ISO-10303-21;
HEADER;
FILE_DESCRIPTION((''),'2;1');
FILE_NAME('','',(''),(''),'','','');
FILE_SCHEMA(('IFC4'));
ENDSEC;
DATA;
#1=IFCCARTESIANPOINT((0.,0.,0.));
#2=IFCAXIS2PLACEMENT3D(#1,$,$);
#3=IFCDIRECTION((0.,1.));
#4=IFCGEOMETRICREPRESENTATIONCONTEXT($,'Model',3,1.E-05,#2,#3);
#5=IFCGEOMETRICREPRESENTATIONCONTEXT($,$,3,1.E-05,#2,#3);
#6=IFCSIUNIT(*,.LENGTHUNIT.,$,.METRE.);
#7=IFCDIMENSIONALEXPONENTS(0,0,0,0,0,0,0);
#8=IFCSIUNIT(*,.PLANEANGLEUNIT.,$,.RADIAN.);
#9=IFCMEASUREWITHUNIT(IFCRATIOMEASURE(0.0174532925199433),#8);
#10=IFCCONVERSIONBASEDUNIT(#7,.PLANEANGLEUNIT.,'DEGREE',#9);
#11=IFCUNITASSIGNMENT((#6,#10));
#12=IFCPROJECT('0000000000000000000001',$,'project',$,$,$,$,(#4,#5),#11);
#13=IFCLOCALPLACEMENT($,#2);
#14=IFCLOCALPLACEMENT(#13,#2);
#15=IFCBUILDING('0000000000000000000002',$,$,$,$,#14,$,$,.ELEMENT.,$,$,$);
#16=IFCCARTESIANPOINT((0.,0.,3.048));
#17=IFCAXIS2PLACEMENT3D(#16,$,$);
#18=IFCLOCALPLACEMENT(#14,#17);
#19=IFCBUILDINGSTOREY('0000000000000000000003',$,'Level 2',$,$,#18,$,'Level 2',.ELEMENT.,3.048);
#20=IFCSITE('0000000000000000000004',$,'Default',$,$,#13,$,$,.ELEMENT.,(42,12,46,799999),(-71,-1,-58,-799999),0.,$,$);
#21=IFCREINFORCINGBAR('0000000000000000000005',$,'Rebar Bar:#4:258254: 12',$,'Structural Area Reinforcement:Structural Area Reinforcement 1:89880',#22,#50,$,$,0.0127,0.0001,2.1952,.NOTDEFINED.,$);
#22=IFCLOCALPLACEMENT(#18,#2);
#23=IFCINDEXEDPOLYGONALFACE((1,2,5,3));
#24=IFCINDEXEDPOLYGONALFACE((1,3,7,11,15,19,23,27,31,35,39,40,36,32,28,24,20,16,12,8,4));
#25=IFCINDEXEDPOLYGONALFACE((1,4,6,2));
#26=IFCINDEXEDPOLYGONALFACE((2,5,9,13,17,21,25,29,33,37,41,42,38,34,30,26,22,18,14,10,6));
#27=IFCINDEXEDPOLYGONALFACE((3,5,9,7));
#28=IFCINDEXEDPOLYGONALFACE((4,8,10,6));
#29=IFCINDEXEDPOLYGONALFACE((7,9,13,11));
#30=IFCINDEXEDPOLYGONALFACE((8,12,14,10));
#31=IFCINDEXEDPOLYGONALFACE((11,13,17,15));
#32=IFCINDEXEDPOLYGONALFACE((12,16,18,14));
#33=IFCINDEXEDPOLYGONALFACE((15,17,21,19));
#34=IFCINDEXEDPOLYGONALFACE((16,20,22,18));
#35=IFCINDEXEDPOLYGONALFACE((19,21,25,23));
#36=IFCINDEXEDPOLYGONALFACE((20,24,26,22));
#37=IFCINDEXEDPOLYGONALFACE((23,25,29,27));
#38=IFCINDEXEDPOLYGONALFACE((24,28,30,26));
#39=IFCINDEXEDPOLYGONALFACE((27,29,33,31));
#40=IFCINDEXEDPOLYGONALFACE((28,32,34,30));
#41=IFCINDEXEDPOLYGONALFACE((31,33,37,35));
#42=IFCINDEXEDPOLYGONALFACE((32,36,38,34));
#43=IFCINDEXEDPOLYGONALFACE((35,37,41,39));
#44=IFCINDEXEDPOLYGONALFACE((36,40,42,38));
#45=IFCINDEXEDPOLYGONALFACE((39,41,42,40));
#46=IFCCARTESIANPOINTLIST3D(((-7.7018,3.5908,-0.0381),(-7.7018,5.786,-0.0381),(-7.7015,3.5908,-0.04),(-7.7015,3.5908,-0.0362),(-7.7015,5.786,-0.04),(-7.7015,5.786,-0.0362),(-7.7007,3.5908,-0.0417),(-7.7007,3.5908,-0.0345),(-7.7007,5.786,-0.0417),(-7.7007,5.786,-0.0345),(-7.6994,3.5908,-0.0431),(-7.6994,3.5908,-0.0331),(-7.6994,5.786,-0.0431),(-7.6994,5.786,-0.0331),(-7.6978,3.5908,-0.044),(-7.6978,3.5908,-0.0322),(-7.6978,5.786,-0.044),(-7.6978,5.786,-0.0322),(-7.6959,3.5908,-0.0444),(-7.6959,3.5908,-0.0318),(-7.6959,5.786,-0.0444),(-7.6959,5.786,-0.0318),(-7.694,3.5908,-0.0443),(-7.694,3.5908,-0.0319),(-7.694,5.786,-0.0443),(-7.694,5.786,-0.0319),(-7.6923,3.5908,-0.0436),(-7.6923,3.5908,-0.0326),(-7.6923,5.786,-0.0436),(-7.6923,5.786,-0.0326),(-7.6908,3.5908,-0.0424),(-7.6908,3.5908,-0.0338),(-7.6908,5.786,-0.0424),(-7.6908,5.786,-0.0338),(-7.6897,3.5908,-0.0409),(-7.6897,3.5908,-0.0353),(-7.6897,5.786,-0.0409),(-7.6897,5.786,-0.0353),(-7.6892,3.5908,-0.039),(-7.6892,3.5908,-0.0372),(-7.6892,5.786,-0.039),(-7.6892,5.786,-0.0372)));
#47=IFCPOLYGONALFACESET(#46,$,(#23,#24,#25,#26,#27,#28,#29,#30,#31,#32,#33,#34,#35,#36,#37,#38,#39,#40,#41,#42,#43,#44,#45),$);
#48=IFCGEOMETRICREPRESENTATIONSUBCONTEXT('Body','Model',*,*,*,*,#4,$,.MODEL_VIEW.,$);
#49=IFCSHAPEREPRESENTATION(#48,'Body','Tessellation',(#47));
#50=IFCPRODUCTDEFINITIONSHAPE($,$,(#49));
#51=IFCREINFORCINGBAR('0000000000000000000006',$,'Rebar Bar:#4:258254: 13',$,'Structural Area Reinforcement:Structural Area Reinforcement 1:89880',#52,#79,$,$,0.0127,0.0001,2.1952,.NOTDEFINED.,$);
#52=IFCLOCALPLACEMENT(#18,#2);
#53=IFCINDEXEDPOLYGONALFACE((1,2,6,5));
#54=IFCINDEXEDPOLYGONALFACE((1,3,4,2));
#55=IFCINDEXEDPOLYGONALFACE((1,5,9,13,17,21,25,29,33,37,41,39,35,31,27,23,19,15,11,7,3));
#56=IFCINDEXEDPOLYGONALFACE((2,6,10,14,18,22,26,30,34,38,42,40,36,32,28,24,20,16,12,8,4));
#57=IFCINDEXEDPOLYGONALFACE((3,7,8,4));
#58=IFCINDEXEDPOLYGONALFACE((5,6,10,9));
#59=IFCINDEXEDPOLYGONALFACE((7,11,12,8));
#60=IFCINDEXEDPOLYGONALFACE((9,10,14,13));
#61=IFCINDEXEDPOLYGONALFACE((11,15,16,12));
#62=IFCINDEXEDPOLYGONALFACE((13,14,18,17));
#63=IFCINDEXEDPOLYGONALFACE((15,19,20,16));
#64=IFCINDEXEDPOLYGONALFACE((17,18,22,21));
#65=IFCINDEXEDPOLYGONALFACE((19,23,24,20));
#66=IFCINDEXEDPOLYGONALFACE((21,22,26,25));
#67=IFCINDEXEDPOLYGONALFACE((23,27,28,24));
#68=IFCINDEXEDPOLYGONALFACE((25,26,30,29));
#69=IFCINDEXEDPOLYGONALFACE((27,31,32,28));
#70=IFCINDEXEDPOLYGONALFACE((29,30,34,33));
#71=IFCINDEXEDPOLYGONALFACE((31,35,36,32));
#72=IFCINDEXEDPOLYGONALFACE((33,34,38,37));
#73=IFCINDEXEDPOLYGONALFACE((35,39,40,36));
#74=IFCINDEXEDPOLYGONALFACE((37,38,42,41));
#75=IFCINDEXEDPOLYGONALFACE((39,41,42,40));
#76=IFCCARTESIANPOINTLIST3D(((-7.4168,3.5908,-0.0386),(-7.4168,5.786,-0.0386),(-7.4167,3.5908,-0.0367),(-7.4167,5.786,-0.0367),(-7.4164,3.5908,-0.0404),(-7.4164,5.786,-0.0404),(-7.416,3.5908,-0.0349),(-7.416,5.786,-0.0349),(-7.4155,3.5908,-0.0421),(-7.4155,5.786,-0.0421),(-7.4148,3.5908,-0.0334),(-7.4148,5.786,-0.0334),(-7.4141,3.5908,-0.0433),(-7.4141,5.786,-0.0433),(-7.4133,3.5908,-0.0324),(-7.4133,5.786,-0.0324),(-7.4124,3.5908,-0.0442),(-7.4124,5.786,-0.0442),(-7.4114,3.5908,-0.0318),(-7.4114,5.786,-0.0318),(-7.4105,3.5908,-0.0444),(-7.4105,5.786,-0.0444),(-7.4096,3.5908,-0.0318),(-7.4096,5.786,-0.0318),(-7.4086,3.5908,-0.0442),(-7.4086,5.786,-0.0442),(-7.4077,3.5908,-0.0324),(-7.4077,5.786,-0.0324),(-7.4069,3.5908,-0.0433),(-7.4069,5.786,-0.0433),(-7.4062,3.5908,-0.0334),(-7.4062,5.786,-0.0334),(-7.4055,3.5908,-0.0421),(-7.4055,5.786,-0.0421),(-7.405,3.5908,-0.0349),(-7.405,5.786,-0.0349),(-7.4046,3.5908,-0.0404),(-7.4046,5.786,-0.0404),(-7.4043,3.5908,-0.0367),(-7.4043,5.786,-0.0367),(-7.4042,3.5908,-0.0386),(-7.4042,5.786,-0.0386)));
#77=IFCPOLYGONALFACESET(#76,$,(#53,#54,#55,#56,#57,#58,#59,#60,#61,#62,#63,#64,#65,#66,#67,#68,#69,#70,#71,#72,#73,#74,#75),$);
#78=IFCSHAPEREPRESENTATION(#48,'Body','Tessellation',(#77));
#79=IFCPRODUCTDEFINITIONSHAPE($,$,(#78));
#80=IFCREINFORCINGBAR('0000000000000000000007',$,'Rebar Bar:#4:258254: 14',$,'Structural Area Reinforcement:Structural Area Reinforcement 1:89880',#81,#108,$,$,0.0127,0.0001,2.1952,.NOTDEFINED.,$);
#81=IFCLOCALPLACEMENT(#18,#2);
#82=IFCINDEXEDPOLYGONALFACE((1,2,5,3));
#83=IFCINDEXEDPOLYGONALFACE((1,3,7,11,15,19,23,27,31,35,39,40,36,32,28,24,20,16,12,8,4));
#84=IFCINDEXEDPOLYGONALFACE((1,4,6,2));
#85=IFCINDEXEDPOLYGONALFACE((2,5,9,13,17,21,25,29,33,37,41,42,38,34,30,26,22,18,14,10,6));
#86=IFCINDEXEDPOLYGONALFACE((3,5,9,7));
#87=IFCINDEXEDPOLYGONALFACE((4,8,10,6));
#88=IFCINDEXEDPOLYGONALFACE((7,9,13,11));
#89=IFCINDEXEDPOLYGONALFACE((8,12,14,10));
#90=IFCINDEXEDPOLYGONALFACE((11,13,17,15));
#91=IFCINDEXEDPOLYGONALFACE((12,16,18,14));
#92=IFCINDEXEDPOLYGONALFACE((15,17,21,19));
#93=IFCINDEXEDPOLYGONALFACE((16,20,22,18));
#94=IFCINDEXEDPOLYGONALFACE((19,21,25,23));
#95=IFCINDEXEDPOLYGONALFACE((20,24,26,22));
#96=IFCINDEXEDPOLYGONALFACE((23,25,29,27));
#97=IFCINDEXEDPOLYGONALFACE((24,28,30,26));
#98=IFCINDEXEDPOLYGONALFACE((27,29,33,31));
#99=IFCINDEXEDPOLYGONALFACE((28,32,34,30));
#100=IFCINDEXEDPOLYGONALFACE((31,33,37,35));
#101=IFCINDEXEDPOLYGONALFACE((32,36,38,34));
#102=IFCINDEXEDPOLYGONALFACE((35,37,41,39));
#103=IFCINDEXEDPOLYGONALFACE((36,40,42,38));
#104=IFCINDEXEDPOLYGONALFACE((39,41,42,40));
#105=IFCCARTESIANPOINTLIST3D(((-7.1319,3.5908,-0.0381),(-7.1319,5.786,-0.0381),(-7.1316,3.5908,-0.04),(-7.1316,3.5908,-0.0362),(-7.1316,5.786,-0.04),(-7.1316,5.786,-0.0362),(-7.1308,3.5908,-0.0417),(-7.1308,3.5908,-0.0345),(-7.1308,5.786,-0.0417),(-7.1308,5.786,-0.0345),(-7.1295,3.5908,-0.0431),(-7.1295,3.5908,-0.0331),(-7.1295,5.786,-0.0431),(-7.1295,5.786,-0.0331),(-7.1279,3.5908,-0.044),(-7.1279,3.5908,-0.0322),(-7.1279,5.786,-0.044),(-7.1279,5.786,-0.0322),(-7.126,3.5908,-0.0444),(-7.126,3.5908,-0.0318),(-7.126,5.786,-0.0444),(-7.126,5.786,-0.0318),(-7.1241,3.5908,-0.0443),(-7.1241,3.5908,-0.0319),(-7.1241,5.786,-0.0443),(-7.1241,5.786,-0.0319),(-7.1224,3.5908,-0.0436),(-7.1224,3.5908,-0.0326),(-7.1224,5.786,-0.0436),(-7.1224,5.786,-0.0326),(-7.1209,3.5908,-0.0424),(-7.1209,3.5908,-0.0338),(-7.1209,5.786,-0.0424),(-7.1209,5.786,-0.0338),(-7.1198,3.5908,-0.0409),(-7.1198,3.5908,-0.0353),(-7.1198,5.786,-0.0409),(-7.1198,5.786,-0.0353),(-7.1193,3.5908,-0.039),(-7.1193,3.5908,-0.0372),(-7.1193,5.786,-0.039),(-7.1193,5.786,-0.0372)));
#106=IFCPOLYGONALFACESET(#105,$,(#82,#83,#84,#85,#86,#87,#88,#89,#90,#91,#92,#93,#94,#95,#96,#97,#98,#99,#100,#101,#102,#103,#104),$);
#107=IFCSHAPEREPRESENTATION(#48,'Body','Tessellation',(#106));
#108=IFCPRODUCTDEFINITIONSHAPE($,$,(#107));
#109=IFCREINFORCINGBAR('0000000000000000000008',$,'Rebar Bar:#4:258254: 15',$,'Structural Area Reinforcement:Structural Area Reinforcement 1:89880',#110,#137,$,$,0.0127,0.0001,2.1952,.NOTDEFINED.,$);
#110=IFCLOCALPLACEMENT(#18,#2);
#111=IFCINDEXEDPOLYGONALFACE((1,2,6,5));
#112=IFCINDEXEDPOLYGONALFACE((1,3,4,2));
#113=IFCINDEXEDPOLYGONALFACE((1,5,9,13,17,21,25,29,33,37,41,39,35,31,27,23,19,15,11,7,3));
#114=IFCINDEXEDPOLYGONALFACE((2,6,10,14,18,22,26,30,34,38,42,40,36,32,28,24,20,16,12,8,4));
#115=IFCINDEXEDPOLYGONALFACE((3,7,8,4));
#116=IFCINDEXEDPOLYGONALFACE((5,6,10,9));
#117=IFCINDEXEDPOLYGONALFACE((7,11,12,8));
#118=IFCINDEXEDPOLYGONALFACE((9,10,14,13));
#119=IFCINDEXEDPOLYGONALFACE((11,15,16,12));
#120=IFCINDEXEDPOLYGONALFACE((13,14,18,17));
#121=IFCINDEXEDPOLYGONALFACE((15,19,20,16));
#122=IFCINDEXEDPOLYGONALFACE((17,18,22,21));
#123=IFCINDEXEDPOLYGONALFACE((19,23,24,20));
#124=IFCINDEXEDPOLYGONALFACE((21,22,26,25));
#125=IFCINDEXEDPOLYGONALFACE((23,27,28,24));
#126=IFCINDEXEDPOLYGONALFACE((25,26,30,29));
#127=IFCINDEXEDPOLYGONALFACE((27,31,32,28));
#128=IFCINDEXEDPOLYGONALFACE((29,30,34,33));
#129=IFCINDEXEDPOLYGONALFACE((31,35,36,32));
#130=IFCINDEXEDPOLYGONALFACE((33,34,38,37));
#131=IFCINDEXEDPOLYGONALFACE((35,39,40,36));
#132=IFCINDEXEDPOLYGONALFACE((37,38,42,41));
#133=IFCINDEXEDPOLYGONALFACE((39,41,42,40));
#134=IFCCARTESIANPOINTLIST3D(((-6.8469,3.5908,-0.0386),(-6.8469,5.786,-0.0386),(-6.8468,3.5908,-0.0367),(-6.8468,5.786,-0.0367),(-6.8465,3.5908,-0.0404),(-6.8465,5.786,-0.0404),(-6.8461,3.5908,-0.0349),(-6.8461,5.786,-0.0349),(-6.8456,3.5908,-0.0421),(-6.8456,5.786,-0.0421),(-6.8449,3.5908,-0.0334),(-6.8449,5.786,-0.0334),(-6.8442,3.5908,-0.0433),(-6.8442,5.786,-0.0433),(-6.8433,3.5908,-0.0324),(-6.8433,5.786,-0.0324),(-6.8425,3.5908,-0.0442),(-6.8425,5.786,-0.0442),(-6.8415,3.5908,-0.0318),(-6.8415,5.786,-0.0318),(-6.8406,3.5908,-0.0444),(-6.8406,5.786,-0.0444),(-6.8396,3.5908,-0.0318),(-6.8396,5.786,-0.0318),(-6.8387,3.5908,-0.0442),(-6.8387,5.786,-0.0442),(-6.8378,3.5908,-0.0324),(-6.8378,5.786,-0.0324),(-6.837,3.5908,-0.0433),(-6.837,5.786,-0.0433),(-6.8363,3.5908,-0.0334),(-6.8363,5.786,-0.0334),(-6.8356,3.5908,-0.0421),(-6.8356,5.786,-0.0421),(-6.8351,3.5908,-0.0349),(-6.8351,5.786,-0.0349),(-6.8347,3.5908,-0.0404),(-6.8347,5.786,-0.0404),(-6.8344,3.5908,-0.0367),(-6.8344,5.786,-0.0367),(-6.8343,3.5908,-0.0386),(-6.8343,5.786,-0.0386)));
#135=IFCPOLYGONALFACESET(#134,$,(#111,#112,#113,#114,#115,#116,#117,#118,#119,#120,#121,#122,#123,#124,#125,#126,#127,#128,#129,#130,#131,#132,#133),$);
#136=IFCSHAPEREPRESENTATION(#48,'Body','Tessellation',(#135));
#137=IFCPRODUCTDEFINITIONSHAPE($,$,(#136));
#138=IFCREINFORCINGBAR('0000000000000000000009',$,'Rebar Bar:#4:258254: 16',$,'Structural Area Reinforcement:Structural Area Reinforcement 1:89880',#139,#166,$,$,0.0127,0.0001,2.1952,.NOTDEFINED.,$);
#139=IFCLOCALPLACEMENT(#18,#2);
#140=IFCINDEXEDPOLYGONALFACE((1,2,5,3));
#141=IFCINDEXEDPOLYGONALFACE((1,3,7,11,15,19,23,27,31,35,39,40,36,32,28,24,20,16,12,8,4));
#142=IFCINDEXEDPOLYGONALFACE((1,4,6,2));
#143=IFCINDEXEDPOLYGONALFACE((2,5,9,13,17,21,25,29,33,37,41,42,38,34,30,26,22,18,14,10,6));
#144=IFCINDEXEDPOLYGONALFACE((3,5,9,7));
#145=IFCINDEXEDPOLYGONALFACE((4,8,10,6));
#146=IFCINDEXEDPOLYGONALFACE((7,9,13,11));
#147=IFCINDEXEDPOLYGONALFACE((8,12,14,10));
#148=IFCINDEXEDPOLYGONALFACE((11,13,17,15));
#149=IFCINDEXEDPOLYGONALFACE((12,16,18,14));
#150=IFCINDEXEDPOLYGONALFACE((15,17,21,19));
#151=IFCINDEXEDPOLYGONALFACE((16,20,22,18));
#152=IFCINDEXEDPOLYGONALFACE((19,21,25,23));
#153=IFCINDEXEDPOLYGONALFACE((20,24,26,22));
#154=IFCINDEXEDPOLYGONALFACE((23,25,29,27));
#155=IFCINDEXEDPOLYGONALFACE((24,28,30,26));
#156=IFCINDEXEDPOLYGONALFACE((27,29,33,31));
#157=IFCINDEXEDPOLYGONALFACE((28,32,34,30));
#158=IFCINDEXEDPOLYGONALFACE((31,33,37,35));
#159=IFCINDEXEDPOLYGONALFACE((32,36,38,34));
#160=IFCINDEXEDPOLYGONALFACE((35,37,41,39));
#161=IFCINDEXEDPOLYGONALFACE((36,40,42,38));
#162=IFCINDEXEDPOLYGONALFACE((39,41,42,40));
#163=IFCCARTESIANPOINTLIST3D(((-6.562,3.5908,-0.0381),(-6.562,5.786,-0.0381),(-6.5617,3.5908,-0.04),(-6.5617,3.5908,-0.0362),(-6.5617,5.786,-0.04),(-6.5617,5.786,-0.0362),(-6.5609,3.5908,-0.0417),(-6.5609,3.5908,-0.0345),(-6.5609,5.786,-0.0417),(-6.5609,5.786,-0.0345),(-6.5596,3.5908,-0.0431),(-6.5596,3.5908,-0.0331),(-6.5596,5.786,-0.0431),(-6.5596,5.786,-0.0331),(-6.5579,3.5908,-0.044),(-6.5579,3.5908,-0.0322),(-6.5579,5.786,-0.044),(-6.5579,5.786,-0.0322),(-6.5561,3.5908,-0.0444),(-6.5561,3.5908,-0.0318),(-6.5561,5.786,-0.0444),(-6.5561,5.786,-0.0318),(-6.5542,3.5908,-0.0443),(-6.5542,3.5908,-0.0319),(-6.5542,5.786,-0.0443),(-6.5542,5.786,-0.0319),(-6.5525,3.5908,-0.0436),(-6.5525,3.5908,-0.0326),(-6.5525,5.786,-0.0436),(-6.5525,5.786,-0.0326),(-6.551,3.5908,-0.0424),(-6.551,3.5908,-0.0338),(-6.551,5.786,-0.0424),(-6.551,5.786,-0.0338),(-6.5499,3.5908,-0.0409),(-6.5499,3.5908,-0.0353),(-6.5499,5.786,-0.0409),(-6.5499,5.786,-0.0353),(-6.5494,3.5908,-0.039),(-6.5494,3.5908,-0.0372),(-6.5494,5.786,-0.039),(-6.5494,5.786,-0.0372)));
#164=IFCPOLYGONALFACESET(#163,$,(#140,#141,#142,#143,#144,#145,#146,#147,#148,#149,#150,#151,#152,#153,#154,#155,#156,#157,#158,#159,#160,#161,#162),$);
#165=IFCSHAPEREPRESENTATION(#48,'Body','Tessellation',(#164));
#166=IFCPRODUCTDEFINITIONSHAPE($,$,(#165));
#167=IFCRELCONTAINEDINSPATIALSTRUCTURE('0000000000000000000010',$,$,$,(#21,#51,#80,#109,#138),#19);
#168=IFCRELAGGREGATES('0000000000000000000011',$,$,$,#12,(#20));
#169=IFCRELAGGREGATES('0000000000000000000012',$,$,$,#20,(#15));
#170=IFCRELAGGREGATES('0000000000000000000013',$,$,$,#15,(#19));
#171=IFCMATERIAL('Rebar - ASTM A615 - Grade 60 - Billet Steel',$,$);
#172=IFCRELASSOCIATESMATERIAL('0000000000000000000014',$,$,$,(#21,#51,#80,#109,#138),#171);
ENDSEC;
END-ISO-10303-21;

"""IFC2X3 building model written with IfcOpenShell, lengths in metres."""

from ifc_helpers import new_model, entity, si_unit, converted_unit, direction, frame, origin, place, context, subcontext, project, spatial, material, element, save


model = new_model("IFC2X3")

# Units and contexts
model_context = context("Model", 3, precision=1e-05, world=origin(), true_north=direction((0.0, 1.0)))
context_of_model = context(None, 3, precision=1e-05, world=origin(), true_north=direction((0.0, 1.0)))
body_context = subcontext(model_context, "Body", "Model", "MODEL_VIEW")
ifc_project = project(units=[si_unit("LENGTHUNIT", "METRE"), converted_unit("PLANEANGLEUNIT", "DEGREE", entity("IfcRatioMeasure", 0.0174532925199433), si_unit("PLANEANGLEUNIT", "RADIAN"), dimensions=[0, 0, 0, 0, 0, 0, 0])], contexts=[model_context, context_of_model])

# Site, building, storey
site_placement = place(None, origin())
site = spatial("IfcSite", under=ifc_project, at=site_placement, Name="Default", CompositionType="ELEMENT", RefLatitude=(42, 12, 46, 799999), RefLongitude=(-71, -1, -58, -799999), RefElevation=0.0)
building_placement = place(site_placement, origin())
building = spatial("IfcBuilding", under=site, at=building_placement, CompositionType="ELEMENT")
storey_placement = place(building_placement, frame((0.0, 0.0, 3.048)))
storey = spatial("IfcBuildingStorey", under=building, at=storey_placement, Name="Level 2", LongName="Level 2", CompositionType="ELEMENT", Elevation=3.048)

# Reinforcing bars
ifc_material_1 = material(Name="Rebar - ASTM A615 - Grade 60 - Billet Steel")
reinforcing_bar_1_placement = place(storey_placement, origin())
element("IfcReinforcingBar", 1, at=reinforcing_bar_1_placement, inside=storey, material=ifc_material_1, Name="Rebar Bar:#4:258254: 12", ObjectType="Structural Area Reinforcement:Structural Area Reinforcement 1:89880", BarLength=2.1952, BarRole="NOTDEFINED", CrossSectionArea=0.0001, NominalDiameter=0.0127, context=body_context, shape_type="AdvancedSweptSolid", body=[
    entity("IfcSweptDiskSolid", entity("IfcCompositeCurve", [entity("IfcCompositeCurveSegment", "CONTINUOUS", True, entity("IfcPolyline", [entity("IfcCartesianPoint", [-7.6955, 5.786, -0.0381]), entity("IfcCartesianPoint", [-7.6955, 3.5908, -0.0381])]))], False), 0.0063, None, 0.0, 1.0),
])
reinforcing_bar_2_placement = place(storey_placement, origin())
element("IfcReinforcingBar", 2, at=reinforcing_bar_2_placement, inside=storey, material=ifc_material_1, Name="Rebar Bar:#4:258254: 13", ObjectType="Structural Area Reinforcement:Structural Area Reinforcement 1:89880", BarLength=2.1952, BarRole="NOTDEFINED", CrossSectionArea=0.0001, NominalDiameter=0.0127, context=body_context, shape_type="AdvancedSweptSolid", body=[
    entity("IfcSweptDiskSolid", entity("IfcCompositeCurve", [entity("IfcCompositeCurveSegment", "CONTINUOUS", True, entity("IfcPolyline", [entity("IfcCartesianPoint", [-7.4105, 5.786, -0.0381]), entity("IfcCartesianPoint", [-7.4105, 3.5908, -0.0381])]))], False), 0.0063, None, 0.0, 1.0),
])
reinforcing_bar_3_placement = place(storey_placement, origin())
element("IfcReinforcingBar", 3, at=reinforcing_bar_3_placement, inside=storey, material=ifc_material_1, Name="Rebar Bar:#4:258254: 14", ObjectType="Structural Area Reinforcement:Structural Area Reinforcement 1:89880", BarLength=2.1952, BarRole="NOTDEFINED", CrossSectionArea=0.0001, NominalDiameter=0.0127, context=body_context, shape_type="AdvancedSweptSolid", body=[
    entity("IfcSweptDiskSolid", entity("IfcCompositeCurve", [entity("IfcCompositeCurveSegment", "CONTINUOUS", True, entity("IfcPolyline", [entity("IfcCartesianPoint", [-7.1255, 5.786, -0.0381]), entity("IfcCartesianPoint", [-7.1255, 3.5908, -0.0381])]))], False), 0.0063, None, 0.0, 1.0),
])
reinforcing_bar_4_placement = place(storey_placement, origin())
element("IfcReinforcingBar", 4, at=reinforcing_bar_4_placement, inside=storey, material=ifc_material_1, Name="Rebar Bar:#4:258254: 15", ObjectType="Structural Area Reinforcement:Structural Area Reinforcement 1:89880", BarLength=2.1952, BarRole="NOTDEFINED", CrossSectionArea=0.0001, NominalDiameter=0.0127, context=body_context, shape_type="AdvancedSweptSolid", body=[
    entity("IfcSweptDiskSolid", entity("IfcCompositeCurve", [entity("IfcCompositeCurveSegment", "CONTINUOUS", True, entity("IfcPolyline", [entity("IfcCartesianPoint", [-6.8406, 5.786, -0.0381]), entity("IfcCartesianPoint", [-6.8406, 3.5908, -0.0381])]))], False), 0.0063, None, 0.0, 1.0),
])
reinforcing_bar_5_placement = place(storey_placement, origin())
element("IfcReinforcingBar", 5, at=reinforcing_bar_5_placement, inside=storey, material=ifc_material_1, Name="Rebar Bar:#4:258254: 16", ObjectType="Structural Area Reinforcement:Structural Area Reinforcement 1:89880", BarLength=2.1952, BarRole="NOTDEFINED", CrossSectionArea=0.0001, NominalDiameter=0.0127, context=body_context, shape_type="AdvancedSweptSolid", body=[
    entity("IfcSweptDiskSolid", entity("IfcCompositeCurve", [entity("IfcCompositeCurveSegment", "CONTINUOUS", True, entity("IfcPolyline", [entity("IfcCartesianPoint", [-6.5556, 5.786, -0.0381]), entity("IfcCartesianPoint", [-6.5556, 3.5908, -0.0381])]))], False), 0.0063, None, 0.0, 1.0),
])

save(model, "model.ifc")
